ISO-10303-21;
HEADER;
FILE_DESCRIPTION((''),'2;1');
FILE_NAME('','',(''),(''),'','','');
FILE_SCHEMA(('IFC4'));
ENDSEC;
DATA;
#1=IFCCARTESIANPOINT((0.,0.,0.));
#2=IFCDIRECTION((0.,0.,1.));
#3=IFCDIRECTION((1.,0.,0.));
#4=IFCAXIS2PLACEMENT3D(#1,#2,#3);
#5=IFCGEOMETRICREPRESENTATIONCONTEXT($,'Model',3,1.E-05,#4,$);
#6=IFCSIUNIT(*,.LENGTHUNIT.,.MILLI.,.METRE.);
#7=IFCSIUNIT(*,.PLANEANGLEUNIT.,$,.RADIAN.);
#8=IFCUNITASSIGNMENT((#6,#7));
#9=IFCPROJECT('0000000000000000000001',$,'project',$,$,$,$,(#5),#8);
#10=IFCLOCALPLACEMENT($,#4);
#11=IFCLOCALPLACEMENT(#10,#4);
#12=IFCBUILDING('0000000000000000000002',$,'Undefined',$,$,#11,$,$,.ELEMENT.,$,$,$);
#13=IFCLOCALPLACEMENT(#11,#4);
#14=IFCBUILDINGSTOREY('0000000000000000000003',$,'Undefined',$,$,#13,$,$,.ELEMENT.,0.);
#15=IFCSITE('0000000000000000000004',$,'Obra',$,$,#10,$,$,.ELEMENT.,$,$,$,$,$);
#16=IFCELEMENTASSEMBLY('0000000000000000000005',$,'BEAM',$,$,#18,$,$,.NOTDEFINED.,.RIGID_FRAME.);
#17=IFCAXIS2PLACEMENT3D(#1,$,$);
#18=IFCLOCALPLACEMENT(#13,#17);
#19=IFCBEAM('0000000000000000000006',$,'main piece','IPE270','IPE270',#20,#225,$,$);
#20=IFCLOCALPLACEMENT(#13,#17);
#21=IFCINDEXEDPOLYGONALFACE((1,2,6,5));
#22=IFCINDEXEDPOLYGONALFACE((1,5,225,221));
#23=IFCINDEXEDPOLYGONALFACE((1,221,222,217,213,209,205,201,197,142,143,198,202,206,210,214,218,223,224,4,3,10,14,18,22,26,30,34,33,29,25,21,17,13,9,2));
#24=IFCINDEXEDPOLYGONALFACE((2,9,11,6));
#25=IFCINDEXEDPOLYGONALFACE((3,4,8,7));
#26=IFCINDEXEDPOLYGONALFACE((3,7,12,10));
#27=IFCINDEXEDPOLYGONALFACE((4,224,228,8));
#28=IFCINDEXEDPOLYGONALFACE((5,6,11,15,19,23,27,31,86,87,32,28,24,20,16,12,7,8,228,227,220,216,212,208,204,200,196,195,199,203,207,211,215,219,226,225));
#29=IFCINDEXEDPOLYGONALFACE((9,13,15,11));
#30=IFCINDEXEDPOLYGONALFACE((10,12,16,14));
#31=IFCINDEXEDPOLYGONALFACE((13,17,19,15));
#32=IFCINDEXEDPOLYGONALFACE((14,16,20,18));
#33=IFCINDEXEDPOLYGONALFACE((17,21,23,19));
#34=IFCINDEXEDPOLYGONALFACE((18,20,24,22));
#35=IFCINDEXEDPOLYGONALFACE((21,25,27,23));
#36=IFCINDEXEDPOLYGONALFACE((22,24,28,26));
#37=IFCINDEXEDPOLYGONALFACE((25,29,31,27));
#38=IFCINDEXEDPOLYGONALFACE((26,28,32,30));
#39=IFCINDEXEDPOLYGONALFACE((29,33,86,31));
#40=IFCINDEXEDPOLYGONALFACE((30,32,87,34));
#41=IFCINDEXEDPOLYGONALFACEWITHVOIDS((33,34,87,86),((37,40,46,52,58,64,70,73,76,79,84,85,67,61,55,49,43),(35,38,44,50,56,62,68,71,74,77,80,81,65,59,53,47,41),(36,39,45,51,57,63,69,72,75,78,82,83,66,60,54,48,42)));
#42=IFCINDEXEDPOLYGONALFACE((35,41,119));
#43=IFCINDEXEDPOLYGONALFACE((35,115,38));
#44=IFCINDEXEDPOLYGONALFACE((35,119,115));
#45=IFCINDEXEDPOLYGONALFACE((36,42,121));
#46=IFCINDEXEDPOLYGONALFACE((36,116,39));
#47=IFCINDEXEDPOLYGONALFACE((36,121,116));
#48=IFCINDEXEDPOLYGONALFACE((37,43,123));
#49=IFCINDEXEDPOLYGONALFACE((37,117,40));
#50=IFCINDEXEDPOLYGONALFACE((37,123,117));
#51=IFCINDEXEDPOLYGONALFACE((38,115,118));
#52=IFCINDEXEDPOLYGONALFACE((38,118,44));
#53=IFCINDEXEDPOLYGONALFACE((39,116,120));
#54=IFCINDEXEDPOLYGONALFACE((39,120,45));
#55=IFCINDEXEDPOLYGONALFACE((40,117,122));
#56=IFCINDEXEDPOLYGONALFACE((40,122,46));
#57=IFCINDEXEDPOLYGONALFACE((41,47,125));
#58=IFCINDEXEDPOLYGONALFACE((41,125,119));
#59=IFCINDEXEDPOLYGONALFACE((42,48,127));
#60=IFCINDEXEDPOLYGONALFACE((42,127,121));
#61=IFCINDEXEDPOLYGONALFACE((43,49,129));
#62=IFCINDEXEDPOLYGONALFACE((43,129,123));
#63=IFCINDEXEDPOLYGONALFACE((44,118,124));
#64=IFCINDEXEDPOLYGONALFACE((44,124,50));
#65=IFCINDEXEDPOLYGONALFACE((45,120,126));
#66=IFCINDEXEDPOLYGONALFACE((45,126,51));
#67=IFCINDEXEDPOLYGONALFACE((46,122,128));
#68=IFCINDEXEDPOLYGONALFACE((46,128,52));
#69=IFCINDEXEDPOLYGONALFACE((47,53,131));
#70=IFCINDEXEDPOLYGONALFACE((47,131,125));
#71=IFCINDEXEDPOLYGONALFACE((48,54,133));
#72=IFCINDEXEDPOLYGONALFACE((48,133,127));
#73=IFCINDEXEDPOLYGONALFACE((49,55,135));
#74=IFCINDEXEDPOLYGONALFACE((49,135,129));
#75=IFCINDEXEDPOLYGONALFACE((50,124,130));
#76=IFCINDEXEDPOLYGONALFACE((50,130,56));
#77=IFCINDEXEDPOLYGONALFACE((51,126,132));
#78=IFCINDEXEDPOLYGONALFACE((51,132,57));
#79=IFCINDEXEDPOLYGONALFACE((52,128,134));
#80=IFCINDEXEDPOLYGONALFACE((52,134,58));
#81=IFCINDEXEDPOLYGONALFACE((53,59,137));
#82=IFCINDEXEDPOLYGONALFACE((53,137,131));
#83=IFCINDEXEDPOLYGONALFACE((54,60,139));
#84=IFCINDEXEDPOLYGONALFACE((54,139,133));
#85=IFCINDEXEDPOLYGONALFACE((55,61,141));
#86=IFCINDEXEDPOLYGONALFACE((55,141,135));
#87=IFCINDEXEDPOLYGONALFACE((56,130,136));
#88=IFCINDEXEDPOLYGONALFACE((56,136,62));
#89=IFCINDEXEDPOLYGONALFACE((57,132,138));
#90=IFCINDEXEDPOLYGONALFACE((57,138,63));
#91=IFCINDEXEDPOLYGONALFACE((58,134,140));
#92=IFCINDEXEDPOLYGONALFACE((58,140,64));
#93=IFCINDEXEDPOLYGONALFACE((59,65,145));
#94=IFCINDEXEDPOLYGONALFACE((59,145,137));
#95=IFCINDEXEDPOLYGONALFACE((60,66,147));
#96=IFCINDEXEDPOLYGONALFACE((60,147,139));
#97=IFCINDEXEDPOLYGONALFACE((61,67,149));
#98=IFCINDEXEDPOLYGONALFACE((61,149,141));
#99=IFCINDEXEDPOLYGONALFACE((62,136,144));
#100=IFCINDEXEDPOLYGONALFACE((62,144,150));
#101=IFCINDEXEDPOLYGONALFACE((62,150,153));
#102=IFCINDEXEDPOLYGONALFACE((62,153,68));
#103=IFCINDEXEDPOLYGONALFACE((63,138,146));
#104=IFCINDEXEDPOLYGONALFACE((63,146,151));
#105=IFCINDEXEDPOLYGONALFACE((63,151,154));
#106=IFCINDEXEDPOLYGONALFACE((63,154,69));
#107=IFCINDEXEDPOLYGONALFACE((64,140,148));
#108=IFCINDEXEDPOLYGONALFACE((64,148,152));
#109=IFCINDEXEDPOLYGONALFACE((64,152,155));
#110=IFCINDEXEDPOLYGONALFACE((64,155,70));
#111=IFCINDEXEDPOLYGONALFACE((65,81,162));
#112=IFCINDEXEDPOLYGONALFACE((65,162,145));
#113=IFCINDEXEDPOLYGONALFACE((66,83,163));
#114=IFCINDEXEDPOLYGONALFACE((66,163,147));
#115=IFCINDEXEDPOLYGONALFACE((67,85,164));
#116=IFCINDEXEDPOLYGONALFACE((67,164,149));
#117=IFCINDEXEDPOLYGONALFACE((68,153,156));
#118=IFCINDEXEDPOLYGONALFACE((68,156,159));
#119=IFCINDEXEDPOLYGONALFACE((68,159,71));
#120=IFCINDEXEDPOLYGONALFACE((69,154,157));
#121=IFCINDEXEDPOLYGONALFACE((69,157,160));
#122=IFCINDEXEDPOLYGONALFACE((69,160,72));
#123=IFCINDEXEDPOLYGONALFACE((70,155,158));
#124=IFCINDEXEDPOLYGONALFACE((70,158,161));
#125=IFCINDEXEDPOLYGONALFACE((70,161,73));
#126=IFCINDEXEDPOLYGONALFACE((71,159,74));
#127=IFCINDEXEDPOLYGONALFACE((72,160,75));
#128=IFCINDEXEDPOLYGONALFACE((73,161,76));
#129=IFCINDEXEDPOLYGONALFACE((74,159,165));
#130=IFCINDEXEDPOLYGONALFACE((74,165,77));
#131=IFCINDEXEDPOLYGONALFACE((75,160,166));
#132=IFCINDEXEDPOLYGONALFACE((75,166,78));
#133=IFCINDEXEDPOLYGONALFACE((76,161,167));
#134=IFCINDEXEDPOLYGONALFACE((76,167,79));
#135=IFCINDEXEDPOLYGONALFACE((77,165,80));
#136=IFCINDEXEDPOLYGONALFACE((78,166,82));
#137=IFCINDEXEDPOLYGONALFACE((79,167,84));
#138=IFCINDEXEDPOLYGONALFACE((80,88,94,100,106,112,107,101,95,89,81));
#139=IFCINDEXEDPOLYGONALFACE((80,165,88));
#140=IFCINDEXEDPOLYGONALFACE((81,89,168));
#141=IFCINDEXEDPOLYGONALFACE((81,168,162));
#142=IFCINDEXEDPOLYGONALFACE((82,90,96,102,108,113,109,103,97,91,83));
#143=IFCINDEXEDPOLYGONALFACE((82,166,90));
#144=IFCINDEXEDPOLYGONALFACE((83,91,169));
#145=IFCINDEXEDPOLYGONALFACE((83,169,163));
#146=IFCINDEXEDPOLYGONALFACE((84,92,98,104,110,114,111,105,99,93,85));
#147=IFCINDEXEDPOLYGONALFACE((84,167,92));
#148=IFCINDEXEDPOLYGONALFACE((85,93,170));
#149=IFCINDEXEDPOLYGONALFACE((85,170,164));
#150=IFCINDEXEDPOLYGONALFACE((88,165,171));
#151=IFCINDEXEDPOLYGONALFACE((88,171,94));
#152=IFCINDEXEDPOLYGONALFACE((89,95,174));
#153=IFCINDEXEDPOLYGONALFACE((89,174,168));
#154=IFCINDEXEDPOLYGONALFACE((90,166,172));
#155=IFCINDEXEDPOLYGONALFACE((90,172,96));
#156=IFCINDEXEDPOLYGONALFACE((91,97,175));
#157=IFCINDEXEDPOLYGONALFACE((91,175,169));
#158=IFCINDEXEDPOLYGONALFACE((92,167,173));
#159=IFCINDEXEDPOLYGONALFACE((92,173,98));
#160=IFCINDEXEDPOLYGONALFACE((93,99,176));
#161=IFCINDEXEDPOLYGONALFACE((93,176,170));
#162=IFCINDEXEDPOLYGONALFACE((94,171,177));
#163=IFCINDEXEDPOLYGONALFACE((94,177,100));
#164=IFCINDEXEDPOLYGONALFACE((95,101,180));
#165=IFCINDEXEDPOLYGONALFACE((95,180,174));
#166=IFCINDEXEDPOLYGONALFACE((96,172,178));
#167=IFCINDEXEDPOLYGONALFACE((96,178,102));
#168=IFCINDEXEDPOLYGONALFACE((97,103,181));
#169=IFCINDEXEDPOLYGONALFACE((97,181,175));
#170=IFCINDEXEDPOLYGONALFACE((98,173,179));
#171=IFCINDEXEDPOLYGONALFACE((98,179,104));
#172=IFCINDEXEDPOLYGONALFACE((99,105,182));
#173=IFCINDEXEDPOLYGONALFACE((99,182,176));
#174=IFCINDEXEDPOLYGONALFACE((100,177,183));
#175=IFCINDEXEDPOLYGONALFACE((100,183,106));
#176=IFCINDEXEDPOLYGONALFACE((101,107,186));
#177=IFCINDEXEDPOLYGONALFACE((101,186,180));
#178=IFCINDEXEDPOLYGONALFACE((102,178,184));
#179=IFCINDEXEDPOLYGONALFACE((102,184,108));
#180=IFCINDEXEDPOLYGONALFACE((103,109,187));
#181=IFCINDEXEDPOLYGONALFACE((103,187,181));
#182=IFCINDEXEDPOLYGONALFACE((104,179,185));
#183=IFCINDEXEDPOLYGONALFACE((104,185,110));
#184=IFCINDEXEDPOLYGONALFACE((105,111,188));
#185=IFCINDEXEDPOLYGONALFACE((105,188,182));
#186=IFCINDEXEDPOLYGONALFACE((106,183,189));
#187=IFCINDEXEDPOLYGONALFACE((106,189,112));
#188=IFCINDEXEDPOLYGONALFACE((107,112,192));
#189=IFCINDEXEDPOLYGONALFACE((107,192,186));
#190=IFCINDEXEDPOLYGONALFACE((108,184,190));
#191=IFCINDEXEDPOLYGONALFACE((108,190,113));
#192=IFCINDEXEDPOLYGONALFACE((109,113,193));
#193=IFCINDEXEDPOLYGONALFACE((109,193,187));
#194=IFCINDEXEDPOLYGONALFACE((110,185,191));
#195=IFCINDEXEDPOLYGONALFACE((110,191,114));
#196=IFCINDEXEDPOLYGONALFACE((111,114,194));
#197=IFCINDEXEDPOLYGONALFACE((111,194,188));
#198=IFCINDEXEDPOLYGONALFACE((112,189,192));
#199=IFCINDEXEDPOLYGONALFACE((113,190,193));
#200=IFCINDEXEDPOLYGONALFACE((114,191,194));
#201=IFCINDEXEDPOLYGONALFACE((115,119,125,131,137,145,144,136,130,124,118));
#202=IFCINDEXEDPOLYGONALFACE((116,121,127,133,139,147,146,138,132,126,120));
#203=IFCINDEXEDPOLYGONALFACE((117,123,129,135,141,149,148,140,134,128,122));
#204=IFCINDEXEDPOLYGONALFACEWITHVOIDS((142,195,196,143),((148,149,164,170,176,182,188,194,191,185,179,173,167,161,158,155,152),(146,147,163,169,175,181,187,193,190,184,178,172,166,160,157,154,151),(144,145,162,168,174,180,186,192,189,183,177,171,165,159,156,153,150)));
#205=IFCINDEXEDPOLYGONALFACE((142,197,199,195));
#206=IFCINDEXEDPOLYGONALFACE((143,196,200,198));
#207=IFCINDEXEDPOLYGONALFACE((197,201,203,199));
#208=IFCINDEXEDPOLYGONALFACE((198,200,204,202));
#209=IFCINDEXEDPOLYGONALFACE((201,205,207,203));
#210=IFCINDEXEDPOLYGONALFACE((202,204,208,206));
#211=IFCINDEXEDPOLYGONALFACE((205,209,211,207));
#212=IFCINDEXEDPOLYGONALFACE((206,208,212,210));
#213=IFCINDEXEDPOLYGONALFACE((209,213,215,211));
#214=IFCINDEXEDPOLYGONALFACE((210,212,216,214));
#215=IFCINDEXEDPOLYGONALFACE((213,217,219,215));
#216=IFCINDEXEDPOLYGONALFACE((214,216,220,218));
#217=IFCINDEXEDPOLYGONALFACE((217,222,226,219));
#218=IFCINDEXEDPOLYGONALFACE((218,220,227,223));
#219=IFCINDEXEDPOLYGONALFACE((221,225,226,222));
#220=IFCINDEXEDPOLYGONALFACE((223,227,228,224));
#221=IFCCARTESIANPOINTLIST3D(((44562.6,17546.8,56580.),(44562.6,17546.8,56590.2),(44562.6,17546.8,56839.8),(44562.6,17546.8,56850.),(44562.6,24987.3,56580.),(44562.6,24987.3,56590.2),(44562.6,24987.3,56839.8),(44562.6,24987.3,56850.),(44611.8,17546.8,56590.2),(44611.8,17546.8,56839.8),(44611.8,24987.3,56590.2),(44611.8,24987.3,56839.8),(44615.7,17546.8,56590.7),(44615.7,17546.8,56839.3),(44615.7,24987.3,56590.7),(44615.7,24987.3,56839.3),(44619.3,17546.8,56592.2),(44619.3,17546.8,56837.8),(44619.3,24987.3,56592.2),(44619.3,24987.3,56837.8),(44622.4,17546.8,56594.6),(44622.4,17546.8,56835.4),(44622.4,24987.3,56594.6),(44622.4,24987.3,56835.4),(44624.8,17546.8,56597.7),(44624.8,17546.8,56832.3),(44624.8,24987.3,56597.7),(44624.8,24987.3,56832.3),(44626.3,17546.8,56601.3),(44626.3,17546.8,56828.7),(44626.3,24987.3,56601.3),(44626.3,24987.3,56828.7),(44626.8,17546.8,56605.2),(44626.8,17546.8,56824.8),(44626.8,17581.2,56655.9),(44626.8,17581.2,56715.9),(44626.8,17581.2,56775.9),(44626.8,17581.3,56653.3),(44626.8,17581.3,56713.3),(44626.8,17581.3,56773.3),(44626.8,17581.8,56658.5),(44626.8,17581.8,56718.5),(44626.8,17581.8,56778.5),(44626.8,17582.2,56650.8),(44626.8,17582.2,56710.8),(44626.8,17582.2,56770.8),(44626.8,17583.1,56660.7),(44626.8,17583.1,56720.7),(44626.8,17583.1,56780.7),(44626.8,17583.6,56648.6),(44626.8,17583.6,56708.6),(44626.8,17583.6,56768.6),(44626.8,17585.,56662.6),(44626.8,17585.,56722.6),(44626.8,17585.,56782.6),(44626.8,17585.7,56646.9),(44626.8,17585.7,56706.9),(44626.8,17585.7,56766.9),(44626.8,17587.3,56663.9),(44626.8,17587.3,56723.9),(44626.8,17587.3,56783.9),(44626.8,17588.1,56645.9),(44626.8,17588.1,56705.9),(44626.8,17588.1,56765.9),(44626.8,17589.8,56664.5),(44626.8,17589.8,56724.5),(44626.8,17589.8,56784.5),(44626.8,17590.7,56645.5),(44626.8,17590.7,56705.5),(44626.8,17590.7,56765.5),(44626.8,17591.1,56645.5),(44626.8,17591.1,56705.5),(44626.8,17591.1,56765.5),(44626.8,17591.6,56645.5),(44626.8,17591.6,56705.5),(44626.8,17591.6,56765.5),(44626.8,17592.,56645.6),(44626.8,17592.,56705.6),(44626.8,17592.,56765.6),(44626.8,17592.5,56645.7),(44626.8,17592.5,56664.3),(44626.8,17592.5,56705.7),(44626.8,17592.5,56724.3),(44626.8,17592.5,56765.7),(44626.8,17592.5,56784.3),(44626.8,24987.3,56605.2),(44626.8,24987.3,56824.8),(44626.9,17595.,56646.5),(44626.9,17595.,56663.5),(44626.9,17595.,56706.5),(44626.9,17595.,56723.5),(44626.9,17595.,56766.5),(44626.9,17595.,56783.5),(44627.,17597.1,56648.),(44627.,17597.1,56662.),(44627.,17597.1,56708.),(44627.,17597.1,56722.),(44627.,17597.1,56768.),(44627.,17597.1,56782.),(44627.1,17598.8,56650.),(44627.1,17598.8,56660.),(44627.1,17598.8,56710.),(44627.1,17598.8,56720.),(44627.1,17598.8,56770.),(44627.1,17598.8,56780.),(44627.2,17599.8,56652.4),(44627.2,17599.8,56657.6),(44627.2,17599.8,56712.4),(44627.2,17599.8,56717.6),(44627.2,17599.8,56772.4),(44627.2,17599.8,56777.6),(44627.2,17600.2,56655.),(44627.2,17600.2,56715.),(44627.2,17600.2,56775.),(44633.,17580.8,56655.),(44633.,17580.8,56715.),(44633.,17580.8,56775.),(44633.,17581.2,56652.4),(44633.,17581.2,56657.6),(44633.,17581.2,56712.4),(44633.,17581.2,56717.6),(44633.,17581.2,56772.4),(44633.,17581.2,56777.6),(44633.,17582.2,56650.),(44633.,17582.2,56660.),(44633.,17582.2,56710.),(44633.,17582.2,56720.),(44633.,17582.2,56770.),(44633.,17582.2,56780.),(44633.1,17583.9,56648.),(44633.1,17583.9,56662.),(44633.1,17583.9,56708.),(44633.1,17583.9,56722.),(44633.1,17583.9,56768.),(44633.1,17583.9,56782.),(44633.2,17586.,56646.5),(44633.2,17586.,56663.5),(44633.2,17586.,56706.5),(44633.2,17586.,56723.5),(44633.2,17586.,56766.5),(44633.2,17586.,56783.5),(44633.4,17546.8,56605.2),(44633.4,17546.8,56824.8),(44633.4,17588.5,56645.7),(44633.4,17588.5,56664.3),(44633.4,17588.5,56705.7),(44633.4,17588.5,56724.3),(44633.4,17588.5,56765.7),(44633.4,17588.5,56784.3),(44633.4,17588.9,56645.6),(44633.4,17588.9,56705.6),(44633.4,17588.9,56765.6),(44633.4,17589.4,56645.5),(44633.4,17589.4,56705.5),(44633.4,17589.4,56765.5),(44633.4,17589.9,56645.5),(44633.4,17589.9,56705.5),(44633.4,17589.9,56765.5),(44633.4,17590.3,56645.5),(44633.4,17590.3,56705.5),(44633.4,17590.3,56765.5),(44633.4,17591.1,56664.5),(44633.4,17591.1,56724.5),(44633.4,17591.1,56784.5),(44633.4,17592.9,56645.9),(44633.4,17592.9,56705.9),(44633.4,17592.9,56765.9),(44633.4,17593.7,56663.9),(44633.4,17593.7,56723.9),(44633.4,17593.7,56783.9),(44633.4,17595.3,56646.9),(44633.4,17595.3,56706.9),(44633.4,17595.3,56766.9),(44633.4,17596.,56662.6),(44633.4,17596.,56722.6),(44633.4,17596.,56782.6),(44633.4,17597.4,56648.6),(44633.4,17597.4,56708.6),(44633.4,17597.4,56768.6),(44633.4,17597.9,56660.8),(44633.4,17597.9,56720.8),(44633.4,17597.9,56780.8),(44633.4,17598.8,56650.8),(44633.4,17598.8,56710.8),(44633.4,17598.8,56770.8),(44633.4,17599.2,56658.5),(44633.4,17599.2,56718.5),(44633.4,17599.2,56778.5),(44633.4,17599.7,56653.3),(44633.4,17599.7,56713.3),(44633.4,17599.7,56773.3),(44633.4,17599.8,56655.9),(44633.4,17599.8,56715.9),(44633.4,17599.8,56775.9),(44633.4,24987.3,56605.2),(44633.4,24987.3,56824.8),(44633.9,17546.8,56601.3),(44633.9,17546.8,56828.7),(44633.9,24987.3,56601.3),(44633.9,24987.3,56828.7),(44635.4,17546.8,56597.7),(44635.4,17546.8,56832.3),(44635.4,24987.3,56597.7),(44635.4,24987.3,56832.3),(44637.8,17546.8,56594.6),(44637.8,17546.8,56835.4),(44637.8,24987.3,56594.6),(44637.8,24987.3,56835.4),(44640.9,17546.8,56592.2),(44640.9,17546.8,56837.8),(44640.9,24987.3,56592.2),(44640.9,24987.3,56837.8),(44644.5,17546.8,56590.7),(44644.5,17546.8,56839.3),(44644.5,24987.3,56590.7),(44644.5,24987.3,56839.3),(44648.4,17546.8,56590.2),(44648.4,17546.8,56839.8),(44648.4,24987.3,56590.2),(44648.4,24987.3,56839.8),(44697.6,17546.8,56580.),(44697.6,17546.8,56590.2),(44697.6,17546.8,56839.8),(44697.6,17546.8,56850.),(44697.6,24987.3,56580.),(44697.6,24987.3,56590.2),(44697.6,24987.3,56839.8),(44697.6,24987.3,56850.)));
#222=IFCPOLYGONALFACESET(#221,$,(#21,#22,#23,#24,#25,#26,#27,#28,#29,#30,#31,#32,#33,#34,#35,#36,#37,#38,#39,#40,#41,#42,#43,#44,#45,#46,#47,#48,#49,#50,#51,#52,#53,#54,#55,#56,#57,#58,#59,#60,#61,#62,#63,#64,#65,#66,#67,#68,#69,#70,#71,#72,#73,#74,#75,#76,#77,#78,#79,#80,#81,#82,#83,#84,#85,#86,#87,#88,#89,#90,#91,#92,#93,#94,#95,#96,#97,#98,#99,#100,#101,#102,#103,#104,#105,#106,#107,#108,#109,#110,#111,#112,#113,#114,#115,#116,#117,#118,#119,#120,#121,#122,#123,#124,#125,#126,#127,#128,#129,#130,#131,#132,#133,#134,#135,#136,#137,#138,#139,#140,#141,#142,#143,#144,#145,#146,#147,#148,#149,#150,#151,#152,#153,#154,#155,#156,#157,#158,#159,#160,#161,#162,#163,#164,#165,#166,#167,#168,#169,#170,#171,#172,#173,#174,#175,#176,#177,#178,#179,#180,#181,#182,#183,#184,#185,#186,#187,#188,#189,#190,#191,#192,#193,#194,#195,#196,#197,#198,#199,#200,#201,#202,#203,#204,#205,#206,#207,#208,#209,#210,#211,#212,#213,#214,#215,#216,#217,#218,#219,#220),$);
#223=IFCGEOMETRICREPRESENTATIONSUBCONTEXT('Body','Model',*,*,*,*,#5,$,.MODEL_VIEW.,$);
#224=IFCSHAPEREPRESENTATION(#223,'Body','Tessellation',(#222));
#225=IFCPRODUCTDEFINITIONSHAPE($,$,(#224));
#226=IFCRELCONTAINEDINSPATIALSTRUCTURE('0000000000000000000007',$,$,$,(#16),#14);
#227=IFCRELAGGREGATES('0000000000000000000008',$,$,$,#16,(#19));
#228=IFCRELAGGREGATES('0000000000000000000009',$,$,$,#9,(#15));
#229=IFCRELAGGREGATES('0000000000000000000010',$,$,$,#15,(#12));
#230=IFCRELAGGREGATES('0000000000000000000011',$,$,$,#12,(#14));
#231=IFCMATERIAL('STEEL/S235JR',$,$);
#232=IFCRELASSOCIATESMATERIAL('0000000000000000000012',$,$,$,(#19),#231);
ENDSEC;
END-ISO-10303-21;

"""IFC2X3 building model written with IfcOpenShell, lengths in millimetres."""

from ifc_helpers import new_model, si_unit, frame, origin_with_axes, origin_2d_with_axis, place, context, subcontext, project, spatial, circle, i_section, extrude, clip, halfspace, source, transform, mapped, material, element, aggregate, save


model = new_model("IFC2X3")

# Units and contexts
model_context = context("Model", 3, precision=1e-05, world=origin_with_axes())
body_context = subcontext(model_context, "Body", "Model", "MODEL_VIEW")
ifc_project = project(units=[si_unit("LENGTHUNIT", "METRE", prefix="MILLI"), si_unit("PLANEANGLEUNIT", "RADIAN")], contexts=[model_context])

# Site, building, storey
site_placement = place(None, origin_with_axes())
site = spatial("IfcSite", under=ifc_project, at=site_placement, Name="Obra", CompositionType="ELEMENT")
building_placement = place(site_placement, origin_with_axes())
building = spatial("IfcBuilding", under=site, at=building_placement, Name="Undefined", CompositionType="ELEMENT")
storey_placement = place(building_placement, origin_with_axes())
storey = spatial("IfcBuildingStorey", under=building, at=storey_placement, Name="Undefined", CompositionType="ELEMENT", Elevation=0.0)

# Shared definitions
ifc_material_1 = material(Name="STEEL/S235JR")

# Element assembly, beam, opening
shared_shape_1 = source(origin_with_axes(), body_context, "Body", "SweptSolid", [
    extrude(circle(Radius=9.5, at=origin_2d_with_axis()), frame((0.0, 27.6, 0.0), z_axis=(0.0, 1.0, 0.0), x_axis=(1.0, 0.0, 0.0)), (0.0, 0.0, 1.0), 6.8),
])
assembly_1_placement = place(storey_placement, origin_with_axes())
assembly_1 = element("IfcElementAssembly", 1, at=assembly_1_placement, inside=storey, Name="BEAM", AssemblyPlace="NOTDEFINED", PredefinedType="RIGID_FRAME")
beam_1_placement = place(assembly_1_placement, frame((44630.1, 17546.8, 56715.0), z_axis=(0.0, 0.0, 1.0), x_axis=(0.0, 1.0, 0.0)))
beam_1 = element("IfcBeam", 2, at=beam_1_placement, material=ifc_material_1, Name="main piece", Description="IPE270", ObjectType="IPE270", context=body_context, shape_type="Clipping", body=[
    clip(extrude(i_section(OverallWidth=135.0, OverallDepth=270.0, WebThickness=6.6, FlangeThickness=10.2, FilletRadius=15.0, at=origin_2d_with_axis()), frame((7440.5, 0.0, 0.0), z_axis=(-1.0, 0.0, 0.0), x_axis=(0.0, -1.0, 0.0)), (0.0, 0.0, 1.0), 7440.5), halfspace(frame((-4.2, 31.7, -120.0), z_axis=(-0.998473, 0.055249, 0.0), x_axis=(0.0, 0.0, 1.0)), False)),
])
opening_1_placement = place(assembly_1_placement, frame((44658.3, 17538.9, 56835.0), z_axis=(0.055268, 0.998472, 0.0), x_axis=(0.0, 0.0, -1.0)))
element("IfcOpeningElement", 3, at=opening_1_placement, cuts=beam_1, ObjectType="Opening", context=body_context, shape_type="MappedRepresentation", body=[
    mapped(shared_shape_1, transform((60.0, 0.0, 50.0))),
    mapped(shared_shape_1, transform((120.0, 0.0, 50.0))),
    mapped(shared_shape_1, transform((180.0, 0.0, 50.0))),
])
aggregate(assembly_1, [beam_1])

save(model, "model.ifc")
